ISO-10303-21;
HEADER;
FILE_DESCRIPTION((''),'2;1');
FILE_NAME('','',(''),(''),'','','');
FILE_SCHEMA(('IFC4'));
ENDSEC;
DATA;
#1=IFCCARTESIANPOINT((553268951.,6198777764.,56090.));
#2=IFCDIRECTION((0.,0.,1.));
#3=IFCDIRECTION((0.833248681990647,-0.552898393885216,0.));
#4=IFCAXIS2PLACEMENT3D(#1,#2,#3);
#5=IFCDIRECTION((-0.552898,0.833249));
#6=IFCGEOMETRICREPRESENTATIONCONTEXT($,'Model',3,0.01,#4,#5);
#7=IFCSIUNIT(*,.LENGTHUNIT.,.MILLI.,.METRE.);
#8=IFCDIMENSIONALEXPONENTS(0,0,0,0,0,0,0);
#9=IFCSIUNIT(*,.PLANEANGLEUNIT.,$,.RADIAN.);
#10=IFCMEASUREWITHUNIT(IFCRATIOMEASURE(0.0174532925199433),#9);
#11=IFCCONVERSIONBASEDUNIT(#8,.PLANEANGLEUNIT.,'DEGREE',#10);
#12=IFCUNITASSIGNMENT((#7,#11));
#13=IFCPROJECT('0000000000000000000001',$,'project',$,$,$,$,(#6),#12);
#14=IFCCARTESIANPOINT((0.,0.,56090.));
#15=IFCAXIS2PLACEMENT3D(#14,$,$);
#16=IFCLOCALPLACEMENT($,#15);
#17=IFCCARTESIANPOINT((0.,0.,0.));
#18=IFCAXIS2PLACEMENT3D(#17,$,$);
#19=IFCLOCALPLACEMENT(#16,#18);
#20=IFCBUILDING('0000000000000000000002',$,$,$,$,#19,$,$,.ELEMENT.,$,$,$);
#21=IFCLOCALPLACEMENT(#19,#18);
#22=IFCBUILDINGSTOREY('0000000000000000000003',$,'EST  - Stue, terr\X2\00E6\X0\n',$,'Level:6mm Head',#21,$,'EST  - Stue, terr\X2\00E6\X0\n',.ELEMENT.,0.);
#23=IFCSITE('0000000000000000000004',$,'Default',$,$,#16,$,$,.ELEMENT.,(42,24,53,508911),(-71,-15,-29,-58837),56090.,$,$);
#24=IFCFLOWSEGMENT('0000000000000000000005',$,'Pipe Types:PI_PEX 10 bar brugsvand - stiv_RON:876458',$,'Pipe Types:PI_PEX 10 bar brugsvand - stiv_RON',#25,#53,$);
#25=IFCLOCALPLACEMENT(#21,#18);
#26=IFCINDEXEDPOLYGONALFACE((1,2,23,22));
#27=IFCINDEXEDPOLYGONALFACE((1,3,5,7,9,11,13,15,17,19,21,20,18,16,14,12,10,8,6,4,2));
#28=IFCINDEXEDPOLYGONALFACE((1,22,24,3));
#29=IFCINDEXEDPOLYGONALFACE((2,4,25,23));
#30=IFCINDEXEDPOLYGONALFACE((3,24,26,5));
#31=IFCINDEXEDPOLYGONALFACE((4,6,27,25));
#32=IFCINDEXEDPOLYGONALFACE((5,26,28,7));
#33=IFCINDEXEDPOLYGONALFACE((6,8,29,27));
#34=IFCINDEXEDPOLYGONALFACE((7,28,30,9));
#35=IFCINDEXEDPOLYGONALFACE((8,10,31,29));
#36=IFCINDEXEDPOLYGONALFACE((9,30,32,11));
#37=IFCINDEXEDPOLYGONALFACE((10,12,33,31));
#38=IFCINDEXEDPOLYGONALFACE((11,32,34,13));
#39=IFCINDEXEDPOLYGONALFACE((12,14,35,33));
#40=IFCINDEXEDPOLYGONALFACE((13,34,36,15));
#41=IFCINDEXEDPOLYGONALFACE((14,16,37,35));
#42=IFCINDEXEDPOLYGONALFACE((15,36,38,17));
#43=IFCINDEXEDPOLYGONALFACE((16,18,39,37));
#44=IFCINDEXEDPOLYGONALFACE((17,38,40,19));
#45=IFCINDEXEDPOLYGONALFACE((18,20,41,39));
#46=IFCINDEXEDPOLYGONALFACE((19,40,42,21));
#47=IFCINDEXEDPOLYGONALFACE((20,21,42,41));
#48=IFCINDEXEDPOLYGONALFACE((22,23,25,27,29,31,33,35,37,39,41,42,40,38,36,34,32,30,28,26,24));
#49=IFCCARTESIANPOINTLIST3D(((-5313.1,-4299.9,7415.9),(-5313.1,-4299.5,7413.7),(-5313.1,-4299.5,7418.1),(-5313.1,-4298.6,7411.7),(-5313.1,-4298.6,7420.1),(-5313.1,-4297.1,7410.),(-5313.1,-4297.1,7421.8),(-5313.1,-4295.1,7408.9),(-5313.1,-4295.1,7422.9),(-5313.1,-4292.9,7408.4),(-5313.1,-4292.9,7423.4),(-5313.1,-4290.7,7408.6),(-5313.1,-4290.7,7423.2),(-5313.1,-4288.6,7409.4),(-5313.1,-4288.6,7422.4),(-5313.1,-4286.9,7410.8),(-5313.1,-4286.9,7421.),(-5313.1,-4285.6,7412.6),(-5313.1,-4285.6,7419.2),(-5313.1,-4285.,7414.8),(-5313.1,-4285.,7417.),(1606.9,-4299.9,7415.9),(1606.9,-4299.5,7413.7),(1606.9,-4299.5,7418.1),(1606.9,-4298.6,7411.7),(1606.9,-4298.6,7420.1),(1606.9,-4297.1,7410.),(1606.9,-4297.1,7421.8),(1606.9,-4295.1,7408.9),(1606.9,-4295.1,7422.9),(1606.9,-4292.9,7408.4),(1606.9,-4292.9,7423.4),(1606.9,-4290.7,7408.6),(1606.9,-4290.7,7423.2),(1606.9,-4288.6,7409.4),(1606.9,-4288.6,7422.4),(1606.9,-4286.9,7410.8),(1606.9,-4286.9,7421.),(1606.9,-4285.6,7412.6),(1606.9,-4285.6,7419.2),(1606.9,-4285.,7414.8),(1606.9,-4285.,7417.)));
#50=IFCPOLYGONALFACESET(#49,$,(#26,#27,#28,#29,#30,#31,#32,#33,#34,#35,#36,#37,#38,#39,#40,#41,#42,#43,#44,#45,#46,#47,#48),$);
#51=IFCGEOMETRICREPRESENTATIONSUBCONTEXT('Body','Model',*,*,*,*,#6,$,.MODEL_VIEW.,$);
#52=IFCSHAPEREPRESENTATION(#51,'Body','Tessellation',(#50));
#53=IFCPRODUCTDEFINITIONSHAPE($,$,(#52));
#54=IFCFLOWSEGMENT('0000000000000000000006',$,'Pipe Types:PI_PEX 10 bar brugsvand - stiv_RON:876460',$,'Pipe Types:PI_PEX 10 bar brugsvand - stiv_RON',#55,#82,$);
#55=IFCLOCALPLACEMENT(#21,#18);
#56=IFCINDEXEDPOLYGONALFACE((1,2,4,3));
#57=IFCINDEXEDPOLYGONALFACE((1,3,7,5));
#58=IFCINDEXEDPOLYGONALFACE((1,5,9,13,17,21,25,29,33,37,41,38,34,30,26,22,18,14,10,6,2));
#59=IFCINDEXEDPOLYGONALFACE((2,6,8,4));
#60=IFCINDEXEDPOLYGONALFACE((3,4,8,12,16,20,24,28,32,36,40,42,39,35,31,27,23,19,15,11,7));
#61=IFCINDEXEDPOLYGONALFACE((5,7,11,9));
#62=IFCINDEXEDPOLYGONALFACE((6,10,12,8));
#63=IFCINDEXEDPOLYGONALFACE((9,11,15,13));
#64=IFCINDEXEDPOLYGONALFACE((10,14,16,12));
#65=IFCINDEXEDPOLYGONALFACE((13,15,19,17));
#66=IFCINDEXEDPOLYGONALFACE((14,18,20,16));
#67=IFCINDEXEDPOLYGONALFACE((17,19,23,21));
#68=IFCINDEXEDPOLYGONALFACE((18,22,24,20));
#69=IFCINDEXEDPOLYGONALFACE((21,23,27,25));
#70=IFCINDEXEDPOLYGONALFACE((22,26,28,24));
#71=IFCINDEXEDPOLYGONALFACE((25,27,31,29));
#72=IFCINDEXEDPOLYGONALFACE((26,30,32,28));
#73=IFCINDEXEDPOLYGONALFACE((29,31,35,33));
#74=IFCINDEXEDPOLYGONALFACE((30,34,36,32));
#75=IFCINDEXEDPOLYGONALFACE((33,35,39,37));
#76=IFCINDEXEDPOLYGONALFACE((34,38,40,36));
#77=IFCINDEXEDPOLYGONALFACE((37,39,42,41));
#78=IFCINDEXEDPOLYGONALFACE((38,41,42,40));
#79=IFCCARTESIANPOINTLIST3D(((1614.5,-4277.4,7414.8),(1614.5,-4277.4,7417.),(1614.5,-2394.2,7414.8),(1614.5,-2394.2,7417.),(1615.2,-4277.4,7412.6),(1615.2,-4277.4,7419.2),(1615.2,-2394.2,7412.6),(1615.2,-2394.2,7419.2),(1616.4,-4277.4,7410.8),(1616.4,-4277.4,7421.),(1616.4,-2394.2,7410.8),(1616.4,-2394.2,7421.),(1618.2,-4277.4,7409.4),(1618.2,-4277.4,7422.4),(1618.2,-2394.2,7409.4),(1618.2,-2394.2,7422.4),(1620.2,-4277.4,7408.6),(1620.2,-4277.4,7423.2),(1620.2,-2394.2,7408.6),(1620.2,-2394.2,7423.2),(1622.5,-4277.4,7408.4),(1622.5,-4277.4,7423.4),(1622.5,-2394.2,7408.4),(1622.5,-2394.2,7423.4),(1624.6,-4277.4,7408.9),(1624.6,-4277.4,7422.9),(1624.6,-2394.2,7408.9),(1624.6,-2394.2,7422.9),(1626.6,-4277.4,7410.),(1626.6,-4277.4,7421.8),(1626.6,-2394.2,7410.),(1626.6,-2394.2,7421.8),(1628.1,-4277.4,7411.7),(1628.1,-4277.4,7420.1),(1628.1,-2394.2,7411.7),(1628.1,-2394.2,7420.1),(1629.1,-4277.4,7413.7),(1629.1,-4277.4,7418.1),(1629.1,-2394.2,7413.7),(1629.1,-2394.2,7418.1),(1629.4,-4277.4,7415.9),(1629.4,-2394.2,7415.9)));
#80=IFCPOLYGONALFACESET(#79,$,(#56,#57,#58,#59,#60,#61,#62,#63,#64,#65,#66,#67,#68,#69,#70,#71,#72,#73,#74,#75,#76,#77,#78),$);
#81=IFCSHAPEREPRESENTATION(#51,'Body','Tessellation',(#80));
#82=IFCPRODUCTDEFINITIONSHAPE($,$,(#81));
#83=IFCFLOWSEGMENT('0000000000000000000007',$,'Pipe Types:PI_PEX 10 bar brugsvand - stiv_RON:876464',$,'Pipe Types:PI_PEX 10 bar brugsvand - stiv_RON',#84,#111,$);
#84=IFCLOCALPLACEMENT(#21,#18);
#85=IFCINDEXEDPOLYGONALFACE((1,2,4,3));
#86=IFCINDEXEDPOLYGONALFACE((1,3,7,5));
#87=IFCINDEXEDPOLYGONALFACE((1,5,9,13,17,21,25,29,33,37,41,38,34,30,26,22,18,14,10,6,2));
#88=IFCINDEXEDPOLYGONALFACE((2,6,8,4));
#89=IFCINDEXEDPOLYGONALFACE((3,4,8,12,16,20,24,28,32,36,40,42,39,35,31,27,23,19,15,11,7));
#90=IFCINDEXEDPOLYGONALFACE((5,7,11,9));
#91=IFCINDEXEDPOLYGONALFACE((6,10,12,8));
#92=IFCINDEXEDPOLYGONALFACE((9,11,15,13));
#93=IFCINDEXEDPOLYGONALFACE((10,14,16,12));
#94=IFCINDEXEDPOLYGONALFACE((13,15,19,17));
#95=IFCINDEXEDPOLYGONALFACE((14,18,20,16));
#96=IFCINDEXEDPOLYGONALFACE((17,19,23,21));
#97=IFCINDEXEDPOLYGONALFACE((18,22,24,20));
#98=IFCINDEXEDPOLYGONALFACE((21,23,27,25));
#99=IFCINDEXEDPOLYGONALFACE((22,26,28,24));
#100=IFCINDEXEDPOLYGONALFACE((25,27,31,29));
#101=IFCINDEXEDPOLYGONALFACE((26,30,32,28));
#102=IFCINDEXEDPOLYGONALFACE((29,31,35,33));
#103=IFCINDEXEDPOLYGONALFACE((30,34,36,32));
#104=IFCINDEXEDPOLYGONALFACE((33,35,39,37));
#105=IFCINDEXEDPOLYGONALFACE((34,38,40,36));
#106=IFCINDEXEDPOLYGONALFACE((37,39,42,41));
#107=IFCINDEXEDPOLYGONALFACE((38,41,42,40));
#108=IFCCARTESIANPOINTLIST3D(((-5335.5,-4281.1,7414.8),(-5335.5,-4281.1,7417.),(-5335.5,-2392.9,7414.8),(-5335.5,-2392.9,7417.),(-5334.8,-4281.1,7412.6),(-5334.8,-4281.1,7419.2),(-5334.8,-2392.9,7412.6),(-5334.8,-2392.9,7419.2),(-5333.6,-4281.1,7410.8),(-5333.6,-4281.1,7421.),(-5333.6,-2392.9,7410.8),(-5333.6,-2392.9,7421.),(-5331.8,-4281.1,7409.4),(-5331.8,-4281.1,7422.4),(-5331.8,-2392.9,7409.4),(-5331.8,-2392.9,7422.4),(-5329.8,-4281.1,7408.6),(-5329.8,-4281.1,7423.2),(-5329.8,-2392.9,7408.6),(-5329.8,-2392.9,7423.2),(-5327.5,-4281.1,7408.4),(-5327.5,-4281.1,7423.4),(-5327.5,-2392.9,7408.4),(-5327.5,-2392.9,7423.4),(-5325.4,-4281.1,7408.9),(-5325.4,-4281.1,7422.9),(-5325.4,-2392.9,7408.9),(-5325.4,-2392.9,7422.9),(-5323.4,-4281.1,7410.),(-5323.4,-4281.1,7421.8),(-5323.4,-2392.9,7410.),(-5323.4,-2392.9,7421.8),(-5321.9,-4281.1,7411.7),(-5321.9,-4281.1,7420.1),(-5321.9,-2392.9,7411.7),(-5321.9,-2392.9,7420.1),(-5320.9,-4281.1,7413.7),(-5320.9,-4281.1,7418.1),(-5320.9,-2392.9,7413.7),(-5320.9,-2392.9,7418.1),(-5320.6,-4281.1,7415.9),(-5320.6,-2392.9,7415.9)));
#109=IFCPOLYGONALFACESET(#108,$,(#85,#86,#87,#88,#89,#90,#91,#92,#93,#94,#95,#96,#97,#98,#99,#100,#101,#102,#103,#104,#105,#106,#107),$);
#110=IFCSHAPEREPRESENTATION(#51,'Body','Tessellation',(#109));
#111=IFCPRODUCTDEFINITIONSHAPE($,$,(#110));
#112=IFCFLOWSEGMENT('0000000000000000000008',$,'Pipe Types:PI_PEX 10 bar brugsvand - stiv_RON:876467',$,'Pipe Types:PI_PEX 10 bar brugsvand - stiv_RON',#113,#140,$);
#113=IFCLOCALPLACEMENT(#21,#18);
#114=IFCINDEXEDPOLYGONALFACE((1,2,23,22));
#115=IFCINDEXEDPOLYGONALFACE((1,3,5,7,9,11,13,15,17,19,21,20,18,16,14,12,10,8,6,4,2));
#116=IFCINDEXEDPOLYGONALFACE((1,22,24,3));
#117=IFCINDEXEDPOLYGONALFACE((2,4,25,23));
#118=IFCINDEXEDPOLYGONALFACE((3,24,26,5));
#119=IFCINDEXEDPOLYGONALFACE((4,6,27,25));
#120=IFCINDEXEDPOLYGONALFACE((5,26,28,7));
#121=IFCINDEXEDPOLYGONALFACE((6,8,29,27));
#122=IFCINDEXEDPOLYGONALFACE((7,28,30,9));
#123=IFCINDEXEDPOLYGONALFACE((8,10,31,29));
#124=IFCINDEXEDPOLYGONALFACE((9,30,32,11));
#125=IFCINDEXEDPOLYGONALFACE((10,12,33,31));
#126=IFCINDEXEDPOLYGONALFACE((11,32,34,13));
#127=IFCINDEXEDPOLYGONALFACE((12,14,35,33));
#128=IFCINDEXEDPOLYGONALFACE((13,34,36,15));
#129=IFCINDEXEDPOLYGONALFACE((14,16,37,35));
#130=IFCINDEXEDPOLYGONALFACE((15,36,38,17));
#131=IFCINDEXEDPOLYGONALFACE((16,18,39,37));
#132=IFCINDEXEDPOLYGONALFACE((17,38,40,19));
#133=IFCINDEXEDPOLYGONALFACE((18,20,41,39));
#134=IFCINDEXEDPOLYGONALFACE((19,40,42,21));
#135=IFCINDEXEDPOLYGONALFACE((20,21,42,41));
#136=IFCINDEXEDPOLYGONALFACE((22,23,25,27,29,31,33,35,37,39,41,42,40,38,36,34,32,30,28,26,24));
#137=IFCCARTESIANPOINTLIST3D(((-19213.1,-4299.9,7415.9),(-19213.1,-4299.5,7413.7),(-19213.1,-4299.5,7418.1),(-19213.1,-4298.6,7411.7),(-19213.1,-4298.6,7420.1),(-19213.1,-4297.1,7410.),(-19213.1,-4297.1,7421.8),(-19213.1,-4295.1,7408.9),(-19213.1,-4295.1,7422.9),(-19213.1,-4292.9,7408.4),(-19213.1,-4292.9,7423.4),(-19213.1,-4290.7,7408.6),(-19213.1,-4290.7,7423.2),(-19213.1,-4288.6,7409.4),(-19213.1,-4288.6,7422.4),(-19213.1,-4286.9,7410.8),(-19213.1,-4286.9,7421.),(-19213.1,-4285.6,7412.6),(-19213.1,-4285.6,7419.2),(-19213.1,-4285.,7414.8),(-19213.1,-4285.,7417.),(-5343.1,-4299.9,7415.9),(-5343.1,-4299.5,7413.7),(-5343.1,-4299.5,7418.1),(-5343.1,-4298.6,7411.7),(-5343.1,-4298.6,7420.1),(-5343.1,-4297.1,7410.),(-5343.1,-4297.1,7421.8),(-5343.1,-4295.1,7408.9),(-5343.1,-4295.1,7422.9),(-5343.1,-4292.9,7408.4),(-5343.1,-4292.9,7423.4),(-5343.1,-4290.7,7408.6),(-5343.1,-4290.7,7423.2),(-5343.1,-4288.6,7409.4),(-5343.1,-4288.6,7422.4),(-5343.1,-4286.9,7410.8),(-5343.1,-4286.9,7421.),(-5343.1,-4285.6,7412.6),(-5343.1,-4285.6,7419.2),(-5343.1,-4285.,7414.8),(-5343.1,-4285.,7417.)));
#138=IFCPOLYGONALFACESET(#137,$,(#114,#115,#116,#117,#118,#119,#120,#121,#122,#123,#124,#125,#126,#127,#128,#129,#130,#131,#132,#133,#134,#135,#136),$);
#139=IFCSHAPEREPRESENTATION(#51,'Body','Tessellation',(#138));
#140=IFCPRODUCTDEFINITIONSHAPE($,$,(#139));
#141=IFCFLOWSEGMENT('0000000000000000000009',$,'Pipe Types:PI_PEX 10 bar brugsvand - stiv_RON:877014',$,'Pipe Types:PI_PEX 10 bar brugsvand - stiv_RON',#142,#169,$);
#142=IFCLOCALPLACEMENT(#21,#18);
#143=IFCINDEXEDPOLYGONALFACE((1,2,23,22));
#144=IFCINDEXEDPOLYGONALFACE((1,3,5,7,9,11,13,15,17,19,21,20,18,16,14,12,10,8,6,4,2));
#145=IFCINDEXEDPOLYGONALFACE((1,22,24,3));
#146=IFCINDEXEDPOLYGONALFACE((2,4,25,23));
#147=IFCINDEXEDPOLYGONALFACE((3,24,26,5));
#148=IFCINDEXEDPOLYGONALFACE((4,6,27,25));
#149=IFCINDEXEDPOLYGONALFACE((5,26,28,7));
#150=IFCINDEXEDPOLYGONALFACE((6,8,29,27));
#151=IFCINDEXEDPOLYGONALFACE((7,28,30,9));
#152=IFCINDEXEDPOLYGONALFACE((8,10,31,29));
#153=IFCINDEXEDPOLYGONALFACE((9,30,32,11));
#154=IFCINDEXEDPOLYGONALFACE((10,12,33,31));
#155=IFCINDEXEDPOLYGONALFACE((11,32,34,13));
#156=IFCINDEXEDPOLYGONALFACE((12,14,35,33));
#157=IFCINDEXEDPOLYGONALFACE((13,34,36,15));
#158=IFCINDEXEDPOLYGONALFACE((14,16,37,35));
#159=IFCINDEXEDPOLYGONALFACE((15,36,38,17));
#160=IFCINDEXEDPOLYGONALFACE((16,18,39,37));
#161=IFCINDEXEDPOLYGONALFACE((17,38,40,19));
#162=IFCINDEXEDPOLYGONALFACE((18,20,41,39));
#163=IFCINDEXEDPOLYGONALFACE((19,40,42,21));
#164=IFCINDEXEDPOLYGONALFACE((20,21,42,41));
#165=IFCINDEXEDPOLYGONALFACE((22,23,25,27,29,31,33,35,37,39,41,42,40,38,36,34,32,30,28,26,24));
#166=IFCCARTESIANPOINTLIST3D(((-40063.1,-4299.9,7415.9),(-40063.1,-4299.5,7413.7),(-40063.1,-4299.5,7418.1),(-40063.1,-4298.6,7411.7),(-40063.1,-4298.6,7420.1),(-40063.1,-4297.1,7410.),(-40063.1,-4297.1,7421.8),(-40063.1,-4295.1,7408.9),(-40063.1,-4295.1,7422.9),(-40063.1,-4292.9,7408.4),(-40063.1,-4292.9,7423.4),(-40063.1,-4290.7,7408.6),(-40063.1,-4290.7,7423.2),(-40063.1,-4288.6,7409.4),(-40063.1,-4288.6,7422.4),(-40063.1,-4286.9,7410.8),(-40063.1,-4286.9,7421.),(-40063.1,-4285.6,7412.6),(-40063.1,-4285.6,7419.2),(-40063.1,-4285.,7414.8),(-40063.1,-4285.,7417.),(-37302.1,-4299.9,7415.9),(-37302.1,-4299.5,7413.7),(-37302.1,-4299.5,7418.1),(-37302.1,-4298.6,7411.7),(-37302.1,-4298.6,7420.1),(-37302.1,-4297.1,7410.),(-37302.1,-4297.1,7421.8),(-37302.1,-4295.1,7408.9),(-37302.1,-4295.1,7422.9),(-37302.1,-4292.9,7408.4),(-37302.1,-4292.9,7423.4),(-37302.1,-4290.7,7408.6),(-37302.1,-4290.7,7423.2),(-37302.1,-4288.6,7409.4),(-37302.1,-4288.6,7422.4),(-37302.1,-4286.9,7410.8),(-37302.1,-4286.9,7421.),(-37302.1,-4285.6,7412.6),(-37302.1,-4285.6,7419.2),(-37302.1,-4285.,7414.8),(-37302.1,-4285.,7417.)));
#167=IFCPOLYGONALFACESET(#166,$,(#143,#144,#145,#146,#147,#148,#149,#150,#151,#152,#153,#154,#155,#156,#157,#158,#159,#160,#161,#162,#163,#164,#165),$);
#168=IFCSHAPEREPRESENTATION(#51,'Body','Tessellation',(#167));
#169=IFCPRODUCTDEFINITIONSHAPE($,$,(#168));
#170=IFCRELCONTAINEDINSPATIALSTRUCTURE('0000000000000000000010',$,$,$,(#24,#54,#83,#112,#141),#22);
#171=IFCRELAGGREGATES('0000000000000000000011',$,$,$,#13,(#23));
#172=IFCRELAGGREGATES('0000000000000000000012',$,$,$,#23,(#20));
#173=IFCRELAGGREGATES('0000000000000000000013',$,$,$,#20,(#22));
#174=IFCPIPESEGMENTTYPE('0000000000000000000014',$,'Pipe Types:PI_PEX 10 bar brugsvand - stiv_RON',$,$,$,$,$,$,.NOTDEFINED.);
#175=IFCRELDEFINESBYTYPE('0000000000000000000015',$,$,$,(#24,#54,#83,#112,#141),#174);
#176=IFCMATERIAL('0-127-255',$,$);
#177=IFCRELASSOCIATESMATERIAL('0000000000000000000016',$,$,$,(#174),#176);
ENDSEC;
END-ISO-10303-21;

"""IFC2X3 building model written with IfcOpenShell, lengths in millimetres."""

from ifc_helpers import new_model, entity, si_unit, converted_unit, direction, frame, origin, origin_2d_with_axis, place, context, subcontext, project, spatial, circle, extrude, material, type_object, element, save


model = new_model("IFC2X3")

# Units and contexts
model_context = context("Model", 3, precision=0.01, world=frame((553268951.0, 6198777764.0, 56090.0), z_axis=(0.0, 0.0, 1.0), x_axis=(0.833248681990647, -0.552898393885216, 0.0)), true_north=direction((-0.552898, 0.833249)))
body_context = subcontext(model_context, "Body", "Model", "MODEL_VIEW")
ifc_project = project(units=[si_unit("LENGTHUNIT", "METRE", prefix="MILLI"), converted_unit("PLANEANGLEUNIT", "DEGREE", entity("IfcRatioMeasure", 0.0174532925199433), si_unit("PLANEANGLEUNIT", "RADIAN"), dimensions=[0, 0, 0, 0, 0, 0, 0])], contexts=[model_context])

# Site, building, storey
site_placement = place(None, frame((0.0, 0.0, 56090.0)))
site = spatial("IfcSite", under=ifc_project, at=site_placement, Name="Default", CompositionType="ELEMENT", RefLatitude=(42, 24, 53, 508911), RefLongitude=(-71, -15, -29, -58837), RefElevation=56090.0)
building_placement = place(site_placement, origin())
building = spatial("IfcBuilding", under=site, at=building_placement, CompositionType="ELEMENT")
storey_placement = place(building_placement, frame((0.0, 0.0, 0.0)))
storey = spatial("IfcBuildingStorey", under=building, at=storey_placement, Name="EST  - Stue, terræn", ObjectType="Level:6mm Head", LongName="EST  - Stue, terræn", CompositionType="ELEMENT", Elevation=0.0)

# Flow segments
ifc_material_1 = material(Name="0-127-255")
pipe_segment_type_1 = type_object("IfcPipeSegmentType", Name="Pipe Types:PI_PEX 10 bar brugsvand - stiv_RON", PredefinedType="NOTDEFINED", material=ifc_material_1)
flow_segment_1_placement = place(storey_placement, origin())
element("IfcFlowSegment", 1, at=flow_segment_1_placement, inside=storey, type_object=pipe_segment_type_1, Name="Pipe Types:PI_PEX 10 bar brugsvand - stiv_RON:876458", ObjectType="Pipe Types:PI_PEX 10 bar brugsvand - stiv_RON", context=body_context, shape_type="SweptSolid", body=[
    extrude(circle(Radius=7.5, at=origin_2d_with_axis()), frame((-5313.1, -4292.4, 7415.9), z_axis=(1.0, 0.0, 0.0), x_axis=(0.0, -1.0, 0.0)), (0.0, 0.0, 1.0), 6920.0),
])
flow_segment_2_placement = place(storey_placement, origin())
element("IfcFlowSegment", 2, at=flow_segment_2_placement, inside=storey, type_object=pipe_segment_type_1, Name="Pipe Types:PI_PEX 10 bar brugsvand - stiv_RON:876460", ObjectType="Pipe Types:PI_PEX 10 bar brugsvand - stiv_RON", context=body_context, shape_type="SweptSolid", body=[
    extrude(circle(Radius=7.5, at=origin_2d_with_axis()), frame((1621.9, -4277.4, 7415.9), z_axis=(0.0, 1.0, 0.0), x_axis=(1.0, 0.0, 0.0)), (0.0, 0.0, 1.0), 1883.2),
])
flow_segment_3_placement = place(storey_placement, origin())
element("IfcFlowSegment", 3, at=flow_segment_3_placement, inside=storey, type_object=pipe_segment_type_1, Name="Pipe Types:PI_PEX 10 bar brugsvand - stiv_RON:876464", ObjectType="Pipe Types:PI_PEX 10 bar brugsvand - stiv_RON", context=body_context, shape_type="SweptSolid", body=[
    extrude(circle(Radius=7.5, at=origin_2d_with_axis()), frame((-5328.1, -4281.1, 7415.9), z_axis=(0.0, 1.0, 0.0), x_axis=(1.0, 0.0, 0.0)), (0.0, 0.0, 1.0), 1888.3),
])
flow_segment_4_placement = place(storey_placement, origin())
element("IfcFlowSegment", 4, at=flow_segment_4_placement, inside=storey, type_object=pipe_segment_type_1, Name="Pipe Types:PI_PEX 10 bar brugsvand - stiv_RON:876467", ObjectType="Pipe Types:PI_PEX 10 bar brugsvand - stiv_RON", context=body_context, shape_type="SweptSolid", body=[
    extrude(circle(Radius=7.5, at=origin_2d_with_axis()), frame((-19213.1, -4292.4, 7415.9), z_axis=(1.0, 0.0, 0.0), x_axis=(0.0, -1.0, 0.0)), (0.0, 0.0, 1.0), 13870.0),
])
flow_segment_5_placement = place(storey_placement, origin())
element("IfcFlowSegment", 5, at=flow_segment_5_placement, inside=storey, type_object=pipe_segment_type_1, Name="Pipe Types:PI_PEX 10 bar brugsvand - stiv_RON:877014", ObjectType="Pipe Types:PI_PEX 10 bar brugsvand - stiv_RON", context=body_context, shape_type="SweptSolid", body=[
    extrude(circle(Radius=7.5, at=origin_2d_with_axis()), frame((-40063.1, -4292.4, 7415.9), z_axis=(1.0, 0.0, 0.0), x_axis=(0.0, -1.0, 0.0)), (0.0, 0.0, 1.0), 2761.0),
])

save(model, "model.ifc")
